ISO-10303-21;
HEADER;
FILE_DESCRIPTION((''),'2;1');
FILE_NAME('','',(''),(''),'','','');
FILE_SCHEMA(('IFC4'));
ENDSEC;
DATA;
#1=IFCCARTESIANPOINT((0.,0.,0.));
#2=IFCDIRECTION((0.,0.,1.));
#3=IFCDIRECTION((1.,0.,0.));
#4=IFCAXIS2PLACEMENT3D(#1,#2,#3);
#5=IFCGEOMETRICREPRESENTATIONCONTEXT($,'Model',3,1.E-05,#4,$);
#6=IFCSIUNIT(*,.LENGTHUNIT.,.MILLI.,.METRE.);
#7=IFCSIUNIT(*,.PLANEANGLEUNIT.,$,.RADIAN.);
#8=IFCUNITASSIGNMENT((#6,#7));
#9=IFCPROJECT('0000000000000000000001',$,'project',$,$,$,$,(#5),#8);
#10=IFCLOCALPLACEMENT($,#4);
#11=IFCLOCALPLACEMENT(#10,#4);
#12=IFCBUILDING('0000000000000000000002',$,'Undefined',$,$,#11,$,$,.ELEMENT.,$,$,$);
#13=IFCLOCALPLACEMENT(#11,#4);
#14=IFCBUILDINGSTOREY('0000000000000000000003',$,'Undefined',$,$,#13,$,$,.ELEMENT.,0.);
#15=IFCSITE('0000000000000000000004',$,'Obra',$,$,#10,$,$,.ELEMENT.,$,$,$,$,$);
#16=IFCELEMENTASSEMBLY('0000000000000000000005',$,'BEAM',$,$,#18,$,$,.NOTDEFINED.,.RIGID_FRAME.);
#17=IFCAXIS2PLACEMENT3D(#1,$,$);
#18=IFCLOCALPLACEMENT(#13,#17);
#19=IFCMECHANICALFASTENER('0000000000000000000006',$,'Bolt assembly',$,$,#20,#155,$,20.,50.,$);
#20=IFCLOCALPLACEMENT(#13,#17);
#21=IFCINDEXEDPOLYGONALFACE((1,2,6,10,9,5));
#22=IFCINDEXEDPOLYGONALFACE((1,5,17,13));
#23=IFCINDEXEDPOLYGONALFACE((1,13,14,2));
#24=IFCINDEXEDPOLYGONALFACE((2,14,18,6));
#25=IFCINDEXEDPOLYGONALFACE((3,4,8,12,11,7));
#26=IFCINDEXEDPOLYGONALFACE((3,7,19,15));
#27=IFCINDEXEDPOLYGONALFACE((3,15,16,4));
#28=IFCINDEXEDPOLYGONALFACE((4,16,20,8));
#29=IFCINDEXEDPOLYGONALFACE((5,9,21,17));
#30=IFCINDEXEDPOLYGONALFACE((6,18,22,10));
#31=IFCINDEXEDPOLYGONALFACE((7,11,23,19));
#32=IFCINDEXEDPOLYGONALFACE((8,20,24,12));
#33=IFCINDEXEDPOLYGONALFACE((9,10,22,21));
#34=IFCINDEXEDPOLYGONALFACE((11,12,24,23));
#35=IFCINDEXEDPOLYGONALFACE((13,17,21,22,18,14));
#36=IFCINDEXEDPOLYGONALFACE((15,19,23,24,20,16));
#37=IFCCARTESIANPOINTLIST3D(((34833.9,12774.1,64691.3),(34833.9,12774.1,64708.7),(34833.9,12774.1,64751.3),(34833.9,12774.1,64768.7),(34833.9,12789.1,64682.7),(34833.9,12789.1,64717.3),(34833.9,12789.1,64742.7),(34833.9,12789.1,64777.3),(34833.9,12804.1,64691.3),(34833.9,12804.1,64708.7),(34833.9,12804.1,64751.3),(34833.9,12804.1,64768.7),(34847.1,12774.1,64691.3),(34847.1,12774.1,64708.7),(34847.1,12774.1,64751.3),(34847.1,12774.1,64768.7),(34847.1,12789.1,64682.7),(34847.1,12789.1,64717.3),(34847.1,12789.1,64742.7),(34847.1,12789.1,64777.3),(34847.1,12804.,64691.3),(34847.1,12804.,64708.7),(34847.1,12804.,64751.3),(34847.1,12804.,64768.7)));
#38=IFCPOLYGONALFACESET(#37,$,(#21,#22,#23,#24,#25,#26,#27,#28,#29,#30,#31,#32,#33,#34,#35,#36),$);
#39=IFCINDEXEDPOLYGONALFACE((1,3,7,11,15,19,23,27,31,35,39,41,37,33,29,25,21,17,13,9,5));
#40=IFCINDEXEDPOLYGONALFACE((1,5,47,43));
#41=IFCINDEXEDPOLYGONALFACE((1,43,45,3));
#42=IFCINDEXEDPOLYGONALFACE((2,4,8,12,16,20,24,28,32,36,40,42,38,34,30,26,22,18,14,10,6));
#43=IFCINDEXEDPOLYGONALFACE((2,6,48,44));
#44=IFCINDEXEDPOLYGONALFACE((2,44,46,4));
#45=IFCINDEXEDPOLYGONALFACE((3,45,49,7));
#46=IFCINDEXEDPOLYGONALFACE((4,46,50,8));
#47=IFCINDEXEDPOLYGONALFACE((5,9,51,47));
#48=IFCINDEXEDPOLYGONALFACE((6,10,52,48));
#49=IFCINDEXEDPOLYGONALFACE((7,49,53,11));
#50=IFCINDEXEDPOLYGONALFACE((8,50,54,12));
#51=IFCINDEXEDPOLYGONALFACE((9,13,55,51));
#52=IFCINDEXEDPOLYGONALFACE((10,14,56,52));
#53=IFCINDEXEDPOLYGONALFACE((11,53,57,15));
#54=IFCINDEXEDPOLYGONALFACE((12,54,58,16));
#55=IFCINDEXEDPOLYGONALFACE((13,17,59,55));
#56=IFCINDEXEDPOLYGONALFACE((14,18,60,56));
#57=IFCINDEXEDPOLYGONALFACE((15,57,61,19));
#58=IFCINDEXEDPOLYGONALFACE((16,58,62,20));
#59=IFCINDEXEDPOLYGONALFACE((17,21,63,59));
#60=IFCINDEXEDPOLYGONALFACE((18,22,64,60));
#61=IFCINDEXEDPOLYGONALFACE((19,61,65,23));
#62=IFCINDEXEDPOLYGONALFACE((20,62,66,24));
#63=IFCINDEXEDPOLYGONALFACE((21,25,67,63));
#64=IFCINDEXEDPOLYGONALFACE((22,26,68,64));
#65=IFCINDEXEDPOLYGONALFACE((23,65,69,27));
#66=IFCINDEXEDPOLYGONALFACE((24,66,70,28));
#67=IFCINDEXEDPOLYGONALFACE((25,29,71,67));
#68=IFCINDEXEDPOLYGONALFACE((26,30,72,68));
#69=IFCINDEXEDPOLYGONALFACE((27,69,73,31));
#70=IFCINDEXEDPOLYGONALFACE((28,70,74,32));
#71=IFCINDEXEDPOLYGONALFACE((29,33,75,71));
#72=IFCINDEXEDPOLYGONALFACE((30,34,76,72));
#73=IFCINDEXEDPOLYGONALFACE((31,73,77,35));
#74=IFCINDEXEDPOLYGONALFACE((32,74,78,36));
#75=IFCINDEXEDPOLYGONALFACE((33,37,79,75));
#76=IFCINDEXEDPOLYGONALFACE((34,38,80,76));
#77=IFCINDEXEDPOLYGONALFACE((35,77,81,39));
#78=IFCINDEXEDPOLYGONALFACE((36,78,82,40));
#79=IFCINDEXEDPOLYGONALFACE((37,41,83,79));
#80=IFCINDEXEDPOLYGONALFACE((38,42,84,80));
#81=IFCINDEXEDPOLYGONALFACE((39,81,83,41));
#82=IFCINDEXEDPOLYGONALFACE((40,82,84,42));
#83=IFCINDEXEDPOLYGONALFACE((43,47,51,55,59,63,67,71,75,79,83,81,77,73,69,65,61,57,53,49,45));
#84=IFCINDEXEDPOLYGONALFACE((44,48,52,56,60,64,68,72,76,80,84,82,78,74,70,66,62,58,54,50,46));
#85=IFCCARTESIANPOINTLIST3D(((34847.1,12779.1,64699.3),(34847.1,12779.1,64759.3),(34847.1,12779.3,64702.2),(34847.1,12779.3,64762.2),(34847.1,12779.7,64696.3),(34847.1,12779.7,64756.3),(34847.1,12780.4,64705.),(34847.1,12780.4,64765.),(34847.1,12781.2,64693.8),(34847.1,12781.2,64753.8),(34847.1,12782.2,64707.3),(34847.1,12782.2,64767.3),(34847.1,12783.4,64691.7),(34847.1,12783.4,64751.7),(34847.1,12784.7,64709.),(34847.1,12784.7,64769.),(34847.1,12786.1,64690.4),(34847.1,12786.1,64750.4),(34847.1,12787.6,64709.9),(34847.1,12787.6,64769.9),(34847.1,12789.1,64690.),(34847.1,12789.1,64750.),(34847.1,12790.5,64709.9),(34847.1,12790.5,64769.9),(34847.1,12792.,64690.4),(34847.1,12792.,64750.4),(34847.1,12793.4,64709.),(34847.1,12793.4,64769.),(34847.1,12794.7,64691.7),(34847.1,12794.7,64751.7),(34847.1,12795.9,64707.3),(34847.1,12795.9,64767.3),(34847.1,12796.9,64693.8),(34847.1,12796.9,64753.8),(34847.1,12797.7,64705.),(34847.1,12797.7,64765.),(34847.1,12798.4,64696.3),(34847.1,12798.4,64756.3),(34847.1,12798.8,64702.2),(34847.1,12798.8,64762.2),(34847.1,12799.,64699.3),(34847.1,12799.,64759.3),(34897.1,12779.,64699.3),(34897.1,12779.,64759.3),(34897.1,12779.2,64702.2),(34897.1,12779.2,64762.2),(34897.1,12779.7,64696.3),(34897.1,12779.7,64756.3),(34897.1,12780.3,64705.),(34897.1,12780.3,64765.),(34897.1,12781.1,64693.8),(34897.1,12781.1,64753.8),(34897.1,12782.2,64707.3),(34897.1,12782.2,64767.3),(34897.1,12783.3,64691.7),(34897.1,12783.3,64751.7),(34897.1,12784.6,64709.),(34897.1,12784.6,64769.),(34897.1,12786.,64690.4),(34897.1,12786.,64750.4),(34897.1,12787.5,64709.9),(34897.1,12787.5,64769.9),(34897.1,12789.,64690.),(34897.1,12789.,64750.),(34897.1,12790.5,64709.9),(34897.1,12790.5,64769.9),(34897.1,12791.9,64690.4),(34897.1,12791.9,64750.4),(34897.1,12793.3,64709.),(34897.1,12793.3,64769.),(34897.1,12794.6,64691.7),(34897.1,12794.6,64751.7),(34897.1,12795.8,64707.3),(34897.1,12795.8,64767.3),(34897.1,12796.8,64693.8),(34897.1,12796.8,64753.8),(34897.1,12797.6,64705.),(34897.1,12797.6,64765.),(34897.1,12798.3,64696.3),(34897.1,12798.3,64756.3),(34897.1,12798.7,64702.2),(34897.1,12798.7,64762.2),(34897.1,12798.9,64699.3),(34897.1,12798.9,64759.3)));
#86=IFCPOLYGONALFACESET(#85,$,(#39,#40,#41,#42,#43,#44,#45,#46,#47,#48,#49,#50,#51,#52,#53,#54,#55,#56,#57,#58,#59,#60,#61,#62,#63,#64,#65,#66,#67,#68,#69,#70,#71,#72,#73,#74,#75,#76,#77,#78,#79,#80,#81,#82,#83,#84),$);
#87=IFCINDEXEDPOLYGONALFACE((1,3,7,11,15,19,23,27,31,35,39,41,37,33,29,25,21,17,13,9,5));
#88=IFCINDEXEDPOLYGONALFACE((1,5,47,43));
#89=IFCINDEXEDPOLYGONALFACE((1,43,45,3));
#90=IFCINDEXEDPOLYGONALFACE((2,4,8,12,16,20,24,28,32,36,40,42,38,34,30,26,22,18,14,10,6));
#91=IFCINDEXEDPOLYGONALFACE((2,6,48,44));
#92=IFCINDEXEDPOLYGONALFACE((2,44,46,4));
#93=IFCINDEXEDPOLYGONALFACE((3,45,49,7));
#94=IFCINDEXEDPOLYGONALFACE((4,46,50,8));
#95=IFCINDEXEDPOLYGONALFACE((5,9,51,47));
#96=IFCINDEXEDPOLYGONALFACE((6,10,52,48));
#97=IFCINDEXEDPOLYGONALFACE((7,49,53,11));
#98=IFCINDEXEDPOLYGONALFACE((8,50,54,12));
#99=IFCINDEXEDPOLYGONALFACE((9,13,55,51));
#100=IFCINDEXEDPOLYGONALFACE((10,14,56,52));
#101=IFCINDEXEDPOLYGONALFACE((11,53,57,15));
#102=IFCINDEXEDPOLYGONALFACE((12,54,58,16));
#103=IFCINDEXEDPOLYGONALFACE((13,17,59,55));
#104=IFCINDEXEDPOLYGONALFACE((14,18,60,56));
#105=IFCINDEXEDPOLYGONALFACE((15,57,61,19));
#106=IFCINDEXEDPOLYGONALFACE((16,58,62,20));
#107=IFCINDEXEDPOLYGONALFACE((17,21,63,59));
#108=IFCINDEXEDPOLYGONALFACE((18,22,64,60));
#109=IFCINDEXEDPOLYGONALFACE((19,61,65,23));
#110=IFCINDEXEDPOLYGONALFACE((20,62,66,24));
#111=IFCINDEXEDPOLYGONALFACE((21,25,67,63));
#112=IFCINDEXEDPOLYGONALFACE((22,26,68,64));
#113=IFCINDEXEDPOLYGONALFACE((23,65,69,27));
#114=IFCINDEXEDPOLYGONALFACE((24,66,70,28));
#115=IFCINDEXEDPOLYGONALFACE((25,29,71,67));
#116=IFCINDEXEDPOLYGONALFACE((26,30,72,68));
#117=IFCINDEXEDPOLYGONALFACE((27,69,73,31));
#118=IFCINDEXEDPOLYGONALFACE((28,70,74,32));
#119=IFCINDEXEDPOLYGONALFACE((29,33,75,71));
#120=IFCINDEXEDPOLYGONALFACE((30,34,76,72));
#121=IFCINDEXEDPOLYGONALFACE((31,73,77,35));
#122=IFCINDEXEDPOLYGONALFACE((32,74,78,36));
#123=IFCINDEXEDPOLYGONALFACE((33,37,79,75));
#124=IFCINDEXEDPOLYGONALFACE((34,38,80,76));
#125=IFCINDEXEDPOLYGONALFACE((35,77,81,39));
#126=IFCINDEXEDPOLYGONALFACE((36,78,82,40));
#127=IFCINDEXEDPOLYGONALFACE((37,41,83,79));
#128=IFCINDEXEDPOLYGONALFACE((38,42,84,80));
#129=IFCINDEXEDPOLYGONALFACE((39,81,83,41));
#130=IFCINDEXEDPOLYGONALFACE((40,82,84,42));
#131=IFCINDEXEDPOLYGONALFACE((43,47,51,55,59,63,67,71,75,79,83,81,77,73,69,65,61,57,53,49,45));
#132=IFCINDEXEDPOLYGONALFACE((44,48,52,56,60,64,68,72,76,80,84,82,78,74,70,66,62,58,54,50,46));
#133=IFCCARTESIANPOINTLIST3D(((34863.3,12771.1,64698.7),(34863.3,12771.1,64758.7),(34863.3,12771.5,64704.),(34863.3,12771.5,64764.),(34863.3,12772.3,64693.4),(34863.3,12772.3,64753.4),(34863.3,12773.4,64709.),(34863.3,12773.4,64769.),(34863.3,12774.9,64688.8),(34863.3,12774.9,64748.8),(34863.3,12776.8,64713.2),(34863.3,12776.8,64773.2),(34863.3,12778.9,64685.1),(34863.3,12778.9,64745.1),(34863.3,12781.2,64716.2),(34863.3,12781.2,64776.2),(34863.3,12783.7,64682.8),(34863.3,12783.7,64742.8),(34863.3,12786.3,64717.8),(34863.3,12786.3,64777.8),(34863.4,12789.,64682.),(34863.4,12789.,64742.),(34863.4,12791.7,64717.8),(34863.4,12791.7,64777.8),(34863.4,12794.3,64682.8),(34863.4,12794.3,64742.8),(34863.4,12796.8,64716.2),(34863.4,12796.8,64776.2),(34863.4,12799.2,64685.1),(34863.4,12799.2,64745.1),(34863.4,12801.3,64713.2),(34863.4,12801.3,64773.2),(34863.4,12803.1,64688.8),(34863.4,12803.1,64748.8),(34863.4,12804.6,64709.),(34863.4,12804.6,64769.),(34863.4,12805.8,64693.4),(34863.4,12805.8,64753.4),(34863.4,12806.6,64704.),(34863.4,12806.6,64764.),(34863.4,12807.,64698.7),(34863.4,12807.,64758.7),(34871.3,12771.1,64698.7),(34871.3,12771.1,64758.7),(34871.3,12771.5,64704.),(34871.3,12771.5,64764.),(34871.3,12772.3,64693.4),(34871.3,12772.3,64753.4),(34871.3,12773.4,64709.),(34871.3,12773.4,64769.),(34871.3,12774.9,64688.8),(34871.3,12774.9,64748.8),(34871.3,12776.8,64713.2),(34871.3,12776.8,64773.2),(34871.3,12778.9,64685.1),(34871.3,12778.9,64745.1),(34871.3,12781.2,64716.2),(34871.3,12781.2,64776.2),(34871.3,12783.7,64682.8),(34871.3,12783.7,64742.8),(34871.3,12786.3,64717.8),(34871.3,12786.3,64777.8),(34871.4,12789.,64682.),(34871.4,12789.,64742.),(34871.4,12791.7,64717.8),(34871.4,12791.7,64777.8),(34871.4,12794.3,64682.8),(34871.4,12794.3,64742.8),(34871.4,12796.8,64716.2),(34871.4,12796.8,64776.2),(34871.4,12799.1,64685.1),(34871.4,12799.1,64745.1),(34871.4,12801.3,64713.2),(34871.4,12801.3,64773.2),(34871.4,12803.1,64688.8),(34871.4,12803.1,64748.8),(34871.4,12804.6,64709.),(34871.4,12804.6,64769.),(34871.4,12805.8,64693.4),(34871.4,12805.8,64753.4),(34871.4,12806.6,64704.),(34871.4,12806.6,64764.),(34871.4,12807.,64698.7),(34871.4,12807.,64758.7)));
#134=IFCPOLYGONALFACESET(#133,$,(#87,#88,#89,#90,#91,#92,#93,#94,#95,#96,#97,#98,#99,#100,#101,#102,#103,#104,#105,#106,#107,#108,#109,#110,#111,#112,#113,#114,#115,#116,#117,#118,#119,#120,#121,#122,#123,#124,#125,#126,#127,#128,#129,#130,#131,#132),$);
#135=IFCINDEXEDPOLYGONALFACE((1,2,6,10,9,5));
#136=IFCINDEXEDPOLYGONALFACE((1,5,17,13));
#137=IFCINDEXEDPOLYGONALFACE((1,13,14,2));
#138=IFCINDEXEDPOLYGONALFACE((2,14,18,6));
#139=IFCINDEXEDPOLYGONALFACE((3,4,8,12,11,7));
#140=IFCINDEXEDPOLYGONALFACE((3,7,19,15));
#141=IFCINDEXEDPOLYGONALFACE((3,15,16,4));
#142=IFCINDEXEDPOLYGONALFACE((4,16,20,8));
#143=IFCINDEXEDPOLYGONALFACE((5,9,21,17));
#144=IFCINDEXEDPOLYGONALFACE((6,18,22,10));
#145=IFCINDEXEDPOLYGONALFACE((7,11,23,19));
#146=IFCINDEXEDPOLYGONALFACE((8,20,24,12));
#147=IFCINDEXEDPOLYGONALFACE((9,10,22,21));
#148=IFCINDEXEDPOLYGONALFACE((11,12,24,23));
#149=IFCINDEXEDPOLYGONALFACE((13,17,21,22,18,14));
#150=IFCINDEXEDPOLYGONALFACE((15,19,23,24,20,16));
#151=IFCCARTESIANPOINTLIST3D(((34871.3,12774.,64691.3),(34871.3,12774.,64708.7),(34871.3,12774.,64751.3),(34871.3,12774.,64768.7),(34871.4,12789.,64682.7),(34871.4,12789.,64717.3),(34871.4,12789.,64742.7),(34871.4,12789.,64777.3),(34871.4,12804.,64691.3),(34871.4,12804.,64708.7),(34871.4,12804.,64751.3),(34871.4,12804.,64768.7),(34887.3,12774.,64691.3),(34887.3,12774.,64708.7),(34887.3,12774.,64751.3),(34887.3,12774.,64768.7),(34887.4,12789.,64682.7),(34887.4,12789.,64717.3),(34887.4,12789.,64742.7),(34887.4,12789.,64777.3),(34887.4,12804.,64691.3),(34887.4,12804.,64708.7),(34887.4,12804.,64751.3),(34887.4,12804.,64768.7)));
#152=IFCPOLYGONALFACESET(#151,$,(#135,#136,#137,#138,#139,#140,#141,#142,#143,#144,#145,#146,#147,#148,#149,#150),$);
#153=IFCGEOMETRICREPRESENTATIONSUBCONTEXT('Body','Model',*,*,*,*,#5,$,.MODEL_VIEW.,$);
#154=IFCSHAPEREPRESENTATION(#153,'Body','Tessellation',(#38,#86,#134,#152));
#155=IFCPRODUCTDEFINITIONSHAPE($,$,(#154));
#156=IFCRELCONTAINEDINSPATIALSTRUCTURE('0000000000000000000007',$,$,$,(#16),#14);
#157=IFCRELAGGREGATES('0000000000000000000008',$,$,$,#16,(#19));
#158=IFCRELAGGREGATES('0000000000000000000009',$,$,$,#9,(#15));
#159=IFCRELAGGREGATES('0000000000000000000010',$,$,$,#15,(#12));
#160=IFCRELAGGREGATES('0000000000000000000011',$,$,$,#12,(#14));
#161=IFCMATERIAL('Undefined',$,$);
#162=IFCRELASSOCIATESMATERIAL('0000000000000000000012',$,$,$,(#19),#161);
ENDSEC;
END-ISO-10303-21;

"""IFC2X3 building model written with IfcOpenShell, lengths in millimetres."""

from ifc_helpers import new_model, si_unit, frame, origin_with_axes, origin_2d_with_axis, place, context, subcontext, project, spatial, polyline, circle, outline, extrude, source, transform, mapped, material, element, aggregate, save


model = new_model("IFC2X3")

# Units and contexts
model_context = context("Model", 3, precision=1e-05, world=origin_with_axes())
body_context = subcontext(model_context, "Body", "Model", "MODEL_VIEW")
ifc_project = project(units=[si_unit("LENGTHUNIT", "METRE", prefix="MILLI"), si_unit("PLANEANGLEUNIT", "RADIAN")], contexts=[model_context])

# Site, building, storey
site_placement = place(None, origin_with_axes())
site = spatial("IfcSite", under=ifc_project, at=site_placement, Name="Obra", CompositionType="ELEMENT")
building_placement = place(site_placement, origin_with_axes())
building = spatial("IfcBuilding", under=site, at=building_placement, Name="Undefined", CompositionType="ELEMENT")
storey_placement = place(building_placement, origin_with_axes())
storey = spatial("IfcBuildingStorey", under=building, at=storey_placement, Name="Undefined", CompositionType="ELEMENT", Elevation=0.0)

# Shared definitions
ifc_material = material(Name="Undefined")

# Element assembly
assembly_1_placement = place(storey_placement, origin_with_axes())
assembly_1 = element("IfcElementAssembly", 1, at=assembly_1_placement, inside=storey, Name="BEAM", AssemblyPlace="NOTDEFINED", PredefinedType="RIGID_FRAME")

# Mechanical fastener
shared_shape_1 = source(origin_with_axes(), body_context, "Body", "SweptSolid", [
    extrude(outline(polyline([(17.3, 0.0), (8.7, 15.0), (-8.7, 15.0), (-17.3, 0.0), (-8.7, -15.0), (8.7, -15.0), (17.3, 0.0)])), frame((0.0, -26.3, 0.0), z_axis=(0.0, 1.0, 0.0), x_axis=(1.0, 0.0, 0.0)), (0.0, 0.0, 1.0), 13.2),
    extrude(circle(Radius=10.0, at=origin_2d_with_axis()), frame((0.0, -13.1, 0.0), z_axis=(0.0, 1.0, 0.0), x_axis=(1.0, 0.0, 0.0)), (0.0, 0.0, 1.0), 50.0),
    extrude(circle(Radius=18.0, at=origin_2d_with_axis()), frame((0.0, 3.2, 0.0), z_axis=(0.0, 1.0, 0.0), x_axis=(1.0, 0.0, 0.0)), (0.0, 0.0, 1.0), 8.0),
    extrude(outline(polyline([(17.3, 0.0), (8.7, 15.0), (-8.7, 15.0), (-17.3, 0.0), (-8.7, -15.0), (8.7, -15.0), (17.3, 0.0)])), frame((0.0, 11.2, 0.0), z_axis=(0.0, 1.0, 0.0), x_axis=(1.0, 0.0, 0.0)), (0.0, 0.0, 1.0), 16.0),
])
mechanical_fastener_1_placement = place(assembly_1_placement, frame((34860.3, 12829.0, 64850.0), z_axis=(-0.001707, -0.999999, 0.0), x_axis=(0.0, 0.0, -1.0)))
mechanical_fastener_1 = element("IfcMechanicalFastener", 2, at=mechanical_fastener_1_placement, material=ifc_material, Name="Bolt assembly", NominalDiameter=20.0, NominalLength=50.0, context=body_context, shape_type="MappedRepresentation", body=[
    mapped(shared_shape_1, transform((90.0, 0.0, 40.0))),
    mapped(shared_shape_1, transform((150.0, 0.0, 40.0))),
])
aggregate(assembly_1, [mechanical_fastener_1])

save(model, "model.ifc")
